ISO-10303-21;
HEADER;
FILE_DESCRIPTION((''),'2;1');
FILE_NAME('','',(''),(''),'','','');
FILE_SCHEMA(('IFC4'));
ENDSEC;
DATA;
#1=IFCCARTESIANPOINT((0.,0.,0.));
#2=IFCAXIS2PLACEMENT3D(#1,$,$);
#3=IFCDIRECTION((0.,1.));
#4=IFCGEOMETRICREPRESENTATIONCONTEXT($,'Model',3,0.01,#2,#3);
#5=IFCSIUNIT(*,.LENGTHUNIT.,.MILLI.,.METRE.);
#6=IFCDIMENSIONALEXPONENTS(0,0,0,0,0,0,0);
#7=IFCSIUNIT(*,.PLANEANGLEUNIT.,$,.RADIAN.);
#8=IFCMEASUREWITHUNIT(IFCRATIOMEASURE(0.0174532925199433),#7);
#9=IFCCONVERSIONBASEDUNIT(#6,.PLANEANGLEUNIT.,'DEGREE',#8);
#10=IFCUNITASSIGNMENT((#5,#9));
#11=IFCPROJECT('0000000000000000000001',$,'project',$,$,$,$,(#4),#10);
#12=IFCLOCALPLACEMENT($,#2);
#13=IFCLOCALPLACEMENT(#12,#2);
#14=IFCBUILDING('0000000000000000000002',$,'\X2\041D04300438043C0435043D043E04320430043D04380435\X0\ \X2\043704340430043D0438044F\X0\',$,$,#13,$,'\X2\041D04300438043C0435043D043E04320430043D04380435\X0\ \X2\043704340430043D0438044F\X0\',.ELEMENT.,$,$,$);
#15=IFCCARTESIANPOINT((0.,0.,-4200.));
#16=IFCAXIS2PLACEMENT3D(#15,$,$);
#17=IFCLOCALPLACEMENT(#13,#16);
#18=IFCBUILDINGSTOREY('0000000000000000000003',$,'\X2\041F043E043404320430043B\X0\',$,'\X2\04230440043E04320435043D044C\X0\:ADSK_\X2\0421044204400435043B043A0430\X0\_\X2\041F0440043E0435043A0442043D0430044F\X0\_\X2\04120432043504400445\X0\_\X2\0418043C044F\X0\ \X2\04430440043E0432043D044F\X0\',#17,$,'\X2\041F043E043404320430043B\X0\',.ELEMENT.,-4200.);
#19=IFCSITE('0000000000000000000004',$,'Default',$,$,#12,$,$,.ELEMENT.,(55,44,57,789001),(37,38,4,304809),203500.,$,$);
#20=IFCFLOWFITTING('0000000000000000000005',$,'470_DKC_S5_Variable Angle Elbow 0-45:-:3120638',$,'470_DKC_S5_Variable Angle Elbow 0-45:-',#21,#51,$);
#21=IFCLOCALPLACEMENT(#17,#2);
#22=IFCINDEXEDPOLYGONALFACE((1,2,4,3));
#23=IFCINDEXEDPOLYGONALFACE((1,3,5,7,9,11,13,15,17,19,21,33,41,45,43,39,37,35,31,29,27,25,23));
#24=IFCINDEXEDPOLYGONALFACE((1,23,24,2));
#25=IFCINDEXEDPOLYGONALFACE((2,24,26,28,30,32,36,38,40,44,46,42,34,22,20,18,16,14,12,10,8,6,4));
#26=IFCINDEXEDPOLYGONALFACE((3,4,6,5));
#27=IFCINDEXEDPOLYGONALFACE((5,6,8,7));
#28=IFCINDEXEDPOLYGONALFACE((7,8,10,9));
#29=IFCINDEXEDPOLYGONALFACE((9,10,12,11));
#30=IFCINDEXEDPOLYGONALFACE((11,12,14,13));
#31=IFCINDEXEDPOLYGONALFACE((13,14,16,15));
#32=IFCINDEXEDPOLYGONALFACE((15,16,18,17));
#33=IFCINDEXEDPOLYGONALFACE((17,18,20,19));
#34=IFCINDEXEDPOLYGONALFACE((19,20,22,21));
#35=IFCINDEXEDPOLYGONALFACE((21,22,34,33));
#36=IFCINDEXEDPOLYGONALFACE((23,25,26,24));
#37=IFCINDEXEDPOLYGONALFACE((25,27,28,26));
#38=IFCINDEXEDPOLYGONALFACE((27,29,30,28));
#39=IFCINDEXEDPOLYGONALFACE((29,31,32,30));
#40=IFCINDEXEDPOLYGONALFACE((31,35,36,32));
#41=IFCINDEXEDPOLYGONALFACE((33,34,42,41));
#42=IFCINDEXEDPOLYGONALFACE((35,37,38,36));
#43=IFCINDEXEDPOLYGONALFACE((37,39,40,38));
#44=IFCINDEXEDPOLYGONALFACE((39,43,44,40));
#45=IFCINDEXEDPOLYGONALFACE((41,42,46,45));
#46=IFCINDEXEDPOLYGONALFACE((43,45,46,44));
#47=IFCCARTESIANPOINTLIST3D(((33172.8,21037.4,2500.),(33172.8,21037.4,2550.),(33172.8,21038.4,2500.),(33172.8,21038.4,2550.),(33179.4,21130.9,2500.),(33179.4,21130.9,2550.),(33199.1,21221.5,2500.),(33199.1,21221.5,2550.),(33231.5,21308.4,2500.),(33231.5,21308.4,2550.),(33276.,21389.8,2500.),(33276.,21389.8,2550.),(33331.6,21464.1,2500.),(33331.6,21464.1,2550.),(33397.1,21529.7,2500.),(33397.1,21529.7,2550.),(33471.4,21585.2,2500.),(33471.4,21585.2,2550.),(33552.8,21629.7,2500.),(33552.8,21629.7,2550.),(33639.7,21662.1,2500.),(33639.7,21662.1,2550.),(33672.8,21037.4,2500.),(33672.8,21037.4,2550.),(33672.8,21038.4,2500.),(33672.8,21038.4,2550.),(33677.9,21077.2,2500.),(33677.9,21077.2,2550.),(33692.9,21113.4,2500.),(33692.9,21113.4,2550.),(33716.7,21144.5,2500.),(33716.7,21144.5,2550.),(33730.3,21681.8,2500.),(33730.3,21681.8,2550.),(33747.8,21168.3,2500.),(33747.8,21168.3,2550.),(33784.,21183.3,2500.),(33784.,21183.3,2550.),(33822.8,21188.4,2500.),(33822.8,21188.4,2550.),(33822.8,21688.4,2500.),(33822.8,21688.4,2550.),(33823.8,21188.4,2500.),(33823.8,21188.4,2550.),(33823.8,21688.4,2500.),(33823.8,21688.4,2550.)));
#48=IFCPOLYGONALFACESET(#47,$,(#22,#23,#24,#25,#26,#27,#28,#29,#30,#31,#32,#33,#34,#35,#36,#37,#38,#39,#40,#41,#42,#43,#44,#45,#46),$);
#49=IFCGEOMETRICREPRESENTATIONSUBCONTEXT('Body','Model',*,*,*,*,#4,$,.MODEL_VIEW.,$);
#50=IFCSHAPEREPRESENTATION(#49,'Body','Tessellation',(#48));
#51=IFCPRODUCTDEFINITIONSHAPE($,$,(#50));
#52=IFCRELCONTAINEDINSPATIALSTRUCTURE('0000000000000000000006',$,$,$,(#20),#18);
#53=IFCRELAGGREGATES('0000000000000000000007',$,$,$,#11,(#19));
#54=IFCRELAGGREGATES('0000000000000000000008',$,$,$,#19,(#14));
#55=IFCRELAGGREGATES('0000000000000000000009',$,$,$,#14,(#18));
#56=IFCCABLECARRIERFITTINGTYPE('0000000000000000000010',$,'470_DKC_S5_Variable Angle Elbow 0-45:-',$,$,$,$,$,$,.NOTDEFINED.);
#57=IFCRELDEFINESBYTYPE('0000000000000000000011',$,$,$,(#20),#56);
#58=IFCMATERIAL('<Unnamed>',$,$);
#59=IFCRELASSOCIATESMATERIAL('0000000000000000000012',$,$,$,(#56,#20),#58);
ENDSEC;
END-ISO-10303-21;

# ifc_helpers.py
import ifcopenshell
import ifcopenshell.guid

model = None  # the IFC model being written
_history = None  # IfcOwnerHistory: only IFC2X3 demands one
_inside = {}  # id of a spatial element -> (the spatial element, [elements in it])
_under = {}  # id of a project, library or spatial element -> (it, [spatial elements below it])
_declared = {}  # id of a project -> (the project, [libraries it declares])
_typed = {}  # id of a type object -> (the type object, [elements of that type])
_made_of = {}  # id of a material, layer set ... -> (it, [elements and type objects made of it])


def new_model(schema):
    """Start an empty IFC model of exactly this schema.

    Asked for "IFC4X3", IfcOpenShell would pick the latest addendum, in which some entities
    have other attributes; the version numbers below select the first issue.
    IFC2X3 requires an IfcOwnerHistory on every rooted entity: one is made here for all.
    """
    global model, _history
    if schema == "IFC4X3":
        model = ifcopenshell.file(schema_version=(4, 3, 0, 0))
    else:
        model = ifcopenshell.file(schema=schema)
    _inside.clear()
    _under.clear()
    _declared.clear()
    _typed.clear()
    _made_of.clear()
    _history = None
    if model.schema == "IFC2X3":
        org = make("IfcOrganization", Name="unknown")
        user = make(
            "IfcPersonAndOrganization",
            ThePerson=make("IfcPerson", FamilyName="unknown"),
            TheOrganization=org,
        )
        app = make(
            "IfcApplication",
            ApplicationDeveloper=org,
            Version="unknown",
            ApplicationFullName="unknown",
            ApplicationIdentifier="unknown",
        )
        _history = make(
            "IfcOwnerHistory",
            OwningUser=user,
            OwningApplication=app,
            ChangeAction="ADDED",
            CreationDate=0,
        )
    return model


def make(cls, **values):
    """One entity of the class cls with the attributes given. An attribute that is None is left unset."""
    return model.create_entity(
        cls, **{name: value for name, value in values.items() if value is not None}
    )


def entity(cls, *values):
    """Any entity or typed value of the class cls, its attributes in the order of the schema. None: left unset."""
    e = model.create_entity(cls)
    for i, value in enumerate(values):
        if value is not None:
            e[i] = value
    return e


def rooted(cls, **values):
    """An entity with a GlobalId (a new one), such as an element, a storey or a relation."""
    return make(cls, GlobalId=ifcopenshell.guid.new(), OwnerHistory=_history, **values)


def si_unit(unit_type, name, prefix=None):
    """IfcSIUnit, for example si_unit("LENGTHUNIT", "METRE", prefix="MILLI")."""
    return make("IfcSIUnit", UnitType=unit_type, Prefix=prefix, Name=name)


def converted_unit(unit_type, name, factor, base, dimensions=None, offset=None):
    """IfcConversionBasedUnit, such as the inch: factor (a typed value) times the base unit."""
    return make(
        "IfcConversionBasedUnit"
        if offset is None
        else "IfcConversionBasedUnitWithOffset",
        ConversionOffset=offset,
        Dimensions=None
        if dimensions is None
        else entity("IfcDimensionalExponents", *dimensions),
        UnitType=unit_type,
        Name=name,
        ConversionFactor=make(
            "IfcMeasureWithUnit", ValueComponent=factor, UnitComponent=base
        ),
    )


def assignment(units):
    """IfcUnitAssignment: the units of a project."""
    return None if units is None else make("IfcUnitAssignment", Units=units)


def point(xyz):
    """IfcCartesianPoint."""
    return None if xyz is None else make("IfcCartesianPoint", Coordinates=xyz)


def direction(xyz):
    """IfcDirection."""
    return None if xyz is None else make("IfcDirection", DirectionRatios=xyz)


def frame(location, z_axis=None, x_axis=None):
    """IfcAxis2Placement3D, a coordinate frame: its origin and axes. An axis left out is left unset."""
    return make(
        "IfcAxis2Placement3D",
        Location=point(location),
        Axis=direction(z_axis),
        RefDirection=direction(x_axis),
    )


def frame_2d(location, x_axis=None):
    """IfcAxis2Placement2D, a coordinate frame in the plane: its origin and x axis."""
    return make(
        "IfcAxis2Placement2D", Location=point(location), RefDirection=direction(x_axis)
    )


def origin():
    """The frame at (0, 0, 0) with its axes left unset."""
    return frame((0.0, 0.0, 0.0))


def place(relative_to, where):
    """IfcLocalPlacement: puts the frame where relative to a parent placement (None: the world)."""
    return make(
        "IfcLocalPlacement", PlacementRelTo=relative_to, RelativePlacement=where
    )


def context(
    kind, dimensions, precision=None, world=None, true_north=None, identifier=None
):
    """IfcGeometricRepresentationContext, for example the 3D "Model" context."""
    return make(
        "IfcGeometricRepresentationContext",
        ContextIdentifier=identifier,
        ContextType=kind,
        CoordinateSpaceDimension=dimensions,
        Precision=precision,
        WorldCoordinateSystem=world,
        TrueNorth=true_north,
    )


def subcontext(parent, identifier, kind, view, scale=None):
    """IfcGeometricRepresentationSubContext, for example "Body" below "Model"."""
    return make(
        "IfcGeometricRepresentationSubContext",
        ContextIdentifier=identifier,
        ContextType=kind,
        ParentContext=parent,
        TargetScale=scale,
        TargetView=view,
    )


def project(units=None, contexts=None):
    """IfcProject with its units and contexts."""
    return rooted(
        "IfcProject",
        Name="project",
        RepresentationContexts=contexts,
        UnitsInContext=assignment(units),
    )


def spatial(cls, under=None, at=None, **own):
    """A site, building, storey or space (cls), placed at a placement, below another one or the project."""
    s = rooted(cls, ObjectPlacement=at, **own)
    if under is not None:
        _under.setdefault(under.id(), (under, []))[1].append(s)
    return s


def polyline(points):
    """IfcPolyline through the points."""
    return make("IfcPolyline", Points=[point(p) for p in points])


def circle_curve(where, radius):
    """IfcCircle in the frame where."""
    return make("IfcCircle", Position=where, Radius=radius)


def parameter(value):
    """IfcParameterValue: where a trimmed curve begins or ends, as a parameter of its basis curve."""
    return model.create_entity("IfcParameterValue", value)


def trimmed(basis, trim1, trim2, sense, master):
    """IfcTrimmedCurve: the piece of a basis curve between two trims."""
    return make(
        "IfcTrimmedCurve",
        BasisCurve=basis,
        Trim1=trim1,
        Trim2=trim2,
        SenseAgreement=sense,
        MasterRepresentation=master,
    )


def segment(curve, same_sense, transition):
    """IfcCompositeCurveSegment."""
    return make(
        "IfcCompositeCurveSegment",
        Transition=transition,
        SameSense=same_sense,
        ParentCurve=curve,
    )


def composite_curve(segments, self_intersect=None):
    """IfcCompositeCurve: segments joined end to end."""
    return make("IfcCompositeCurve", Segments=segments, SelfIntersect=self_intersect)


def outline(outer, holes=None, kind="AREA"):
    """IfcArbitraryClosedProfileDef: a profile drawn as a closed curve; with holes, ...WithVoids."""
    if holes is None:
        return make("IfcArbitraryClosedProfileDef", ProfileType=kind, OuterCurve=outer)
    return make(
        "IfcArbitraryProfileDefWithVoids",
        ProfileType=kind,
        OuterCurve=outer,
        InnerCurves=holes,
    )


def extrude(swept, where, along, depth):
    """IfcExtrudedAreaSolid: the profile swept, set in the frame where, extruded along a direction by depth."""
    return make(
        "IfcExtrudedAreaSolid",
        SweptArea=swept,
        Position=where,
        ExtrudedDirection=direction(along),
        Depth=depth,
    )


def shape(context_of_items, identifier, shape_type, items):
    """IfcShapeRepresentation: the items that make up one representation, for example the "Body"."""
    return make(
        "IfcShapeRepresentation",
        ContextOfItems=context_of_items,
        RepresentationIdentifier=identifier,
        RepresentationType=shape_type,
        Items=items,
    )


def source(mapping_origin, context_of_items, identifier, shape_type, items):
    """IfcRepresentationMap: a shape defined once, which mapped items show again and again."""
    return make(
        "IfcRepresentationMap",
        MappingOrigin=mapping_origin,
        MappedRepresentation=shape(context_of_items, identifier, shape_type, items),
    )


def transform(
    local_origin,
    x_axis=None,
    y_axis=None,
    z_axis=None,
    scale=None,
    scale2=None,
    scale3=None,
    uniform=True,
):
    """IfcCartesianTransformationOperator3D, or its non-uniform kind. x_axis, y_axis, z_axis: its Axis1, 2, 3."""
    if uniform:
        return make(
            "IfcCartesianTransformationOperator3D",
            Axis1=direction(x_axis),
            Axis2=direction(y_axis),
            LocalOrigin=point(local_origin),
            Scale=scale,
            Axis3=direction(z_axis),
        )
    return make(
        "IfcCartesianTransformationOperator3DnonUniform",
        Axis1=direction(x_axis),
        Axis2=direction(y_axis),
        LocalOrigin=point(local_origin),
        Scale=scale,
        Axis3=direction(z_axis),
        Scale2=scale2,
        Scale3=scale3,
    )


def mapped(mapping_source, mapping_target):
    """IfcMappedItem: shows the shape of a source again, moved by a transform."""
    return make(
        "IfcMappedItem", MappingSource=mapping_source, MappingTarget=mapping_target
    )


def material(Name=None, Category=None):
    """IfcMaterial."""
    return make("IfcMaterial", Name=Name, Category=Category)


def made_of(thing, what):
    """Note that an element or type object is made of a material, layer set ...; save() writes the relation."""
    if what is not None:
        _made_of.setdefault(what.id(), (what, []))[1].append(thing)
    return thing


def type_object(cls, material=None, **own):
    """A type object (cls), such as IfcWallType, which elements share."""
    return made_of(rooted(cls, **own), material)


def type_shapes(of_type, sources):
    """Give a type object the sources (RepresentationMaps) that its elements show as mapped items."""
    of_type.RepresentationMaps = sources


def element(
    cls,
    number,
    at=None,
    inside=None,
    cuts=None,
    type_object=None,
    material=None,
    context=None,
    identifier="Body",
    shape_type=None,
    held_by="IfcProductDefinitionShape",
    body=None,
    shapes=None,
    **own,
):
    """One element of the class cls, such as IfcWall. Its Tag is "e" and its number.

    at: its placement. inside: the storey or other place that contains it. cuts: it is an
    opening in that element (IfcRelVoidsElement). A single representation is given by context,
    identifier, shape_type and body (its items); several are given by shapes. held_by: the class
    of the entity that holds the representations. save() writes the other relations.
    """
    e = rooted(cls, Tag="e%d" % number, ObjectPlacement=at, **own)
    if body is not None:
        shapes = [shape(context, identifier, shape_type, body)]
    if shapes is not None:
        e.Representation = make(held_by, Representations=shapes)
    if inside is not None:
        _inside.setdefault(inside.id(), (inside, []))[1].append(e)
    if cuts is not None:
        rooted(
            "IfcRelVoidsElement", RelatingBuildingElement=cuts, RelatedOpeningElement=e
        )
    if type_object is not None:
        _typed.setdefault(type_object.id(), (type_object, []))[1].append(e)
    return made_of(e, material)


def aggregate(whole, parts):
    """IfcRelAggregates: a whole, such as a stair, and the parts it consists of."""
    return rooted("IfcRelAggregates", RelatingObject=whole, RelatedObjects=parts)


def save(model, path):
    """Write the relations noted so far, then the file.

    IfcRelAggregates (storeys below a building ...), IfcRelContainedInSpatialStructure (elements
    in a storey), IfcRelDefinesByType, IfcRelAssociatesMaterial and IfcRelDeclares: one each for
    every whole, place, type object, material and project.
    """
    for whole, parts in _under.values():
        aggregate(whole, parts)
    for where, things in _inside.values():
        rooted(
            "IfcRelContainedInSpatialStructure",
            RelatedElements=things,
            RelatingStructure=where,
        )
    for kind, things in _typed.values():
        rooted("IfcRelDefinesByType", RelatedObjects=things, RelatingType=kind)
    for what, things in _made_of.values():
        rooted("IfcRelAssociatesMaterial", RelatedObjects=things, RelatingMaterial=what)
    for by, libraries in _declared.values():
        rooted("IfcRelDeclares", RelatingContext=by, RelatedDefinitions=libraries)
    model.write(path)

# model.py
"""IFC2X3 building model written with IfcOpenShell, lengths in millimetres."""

from ifc_helpers import new_model, entity, si_unit, converted_unit, direction, frame, frame_2d, origin, place, context, subcontext, project, spatial, polyline, circle_curve, parameter, trimmed, segment, composite_curve, outline, extrude, source, transform, mapped, material, type_object, type_shapes, element, save


model = new_model("IFC2X3")

# Units and contexts
model_context = context("Model", 3, precision=0.01, world=origin(), true_north=direction((0.0, 1.0)))
body_context = subcontext(model_context, "Body", "Model", "MODEL_VIEW")
ifc_project = project(units=[si_unit("LENGTHUNIT", "METRE", prefix="MILLI"), converted_unit("PLANEANGLEUNIT", "DEGREE", entity("IfcRatioMeasure", 0.0174532925199433), si_unit("PLANEANGLEUNIT", "RADIAN"), dimensions=[0, 0, 0, 0, 0, 0, 0])], contexts=[model_context])

# Site, building, storey
site_placement = place(None, origin())
site = spatial("IfcSite", under=ifc_project, at=site_placement, Name="Default", CompositionType="ELEMENT", RefLatitude=(55, 44, 57, 789001), RefLongitude=(37, 38, 4, 304809), RefElevation=203500.0)
building_placement = place(site_placement, origin())
building = spatial("IfcBuilding", under=site, at=building_placement, Name="Наименование здания", LongName="Наименование здания", CompositionType="ELEMENT")
storey_placement = place(building_placement, frame((0.0, 0.0, -4200.0)))
storey = spatial("IfcBuildingStorey", under=building, at=storey_placement, Name="Подвал", ObjectType="Уровень:ADSK_Стрелка_Проектная_Вверх_Имя уровня", LongName="Подвал", CompositionType="ELEMENT", Elevation=-4200.0)

# Flow fitting
ifc_material_1 = material(Name="<Unnamed>")
cable_carrier_fitting_type_1 = type_object("IfcCableCarrierFittingType", Name="470_DKC_S5_Variable Angle Elbow 0-45:-", PredefinedType="NOTDEFINED", material=ifc_material_1)
shared_shape_1 = source(origin(), body_context, "Body", "SweptSolid", [
    extrude(outline(composite_curve([segment(polyline([(-200.8, -450.2), (-199.8, -450.2)]), True, "CONTINUOUS"), segment(trimmed(circle_curve(frame_2d((-199.8, 199.8), x_axis=(0.0, -1.0)), 650.0), [parameter(0.0)], [parameter(90.0)], True, "PARAMETER"), True, "CONTINUOUS"), segment(polyline([(450.2, 199.8), (450.2, 200.8)]), True, "CONTINUOUS"), segment(polyline([(450.2, 200.8), (-49.8, 200.8)]), True, "CONTINUOUS"), segment(polyline([(-49.8, 200.8), (-49.8, 199.8)]), True, "CONTINUOUS"), segment(trimmed(circle_curve(frame_2d((-199.8, 199.8), x_axis=(0.0, -1.0)), 150.0), [parameter(0.0)], [parameter(90.0)], True, "PARAMETER"), False, "CONTINUOUS"), segment(polyline([(-199.8, 49.8), (-200.8, 49.8)]), True, "CONTINUOUS"), segment(polyline([(-200.8, 49.8), (-200.8, -450.2)]), True, "CONTINUOUS")], self_intersect=False)), frame((-200.2, 200.2, -25.0)), (0.0, 0.0, 1.0), 50.0),
])
type_shapes(cable_carrier_fitting_type_1, [shared_shape_1])
flow_fitting_1_placement = place(storey_placement, frame((33422.8, 21438.4, 2525.0), z_axis=(0.0, 0.0, 1.0), x_axis=(-1.0, 0.0, 0.0)))
element("IfcFlowFitting", 1, at=flow_fitting_1_placement, inside=storey, type_object=cable_carrier_fitting_type_1, material=ifc_material_1, Name="470_DKC_S5_Variable Angle Elbow 0-45:-:3120638", ObjectType="470_DKC_S5_Variable Angle Elbow 0-45:-", context=body_context, shape_type="MappedRepresentation", body=[
    mapped(shared_shape_1, transform((0.0, 0.0, 0.0), scale=1.0)),
])

save(model, "model.ifc")
